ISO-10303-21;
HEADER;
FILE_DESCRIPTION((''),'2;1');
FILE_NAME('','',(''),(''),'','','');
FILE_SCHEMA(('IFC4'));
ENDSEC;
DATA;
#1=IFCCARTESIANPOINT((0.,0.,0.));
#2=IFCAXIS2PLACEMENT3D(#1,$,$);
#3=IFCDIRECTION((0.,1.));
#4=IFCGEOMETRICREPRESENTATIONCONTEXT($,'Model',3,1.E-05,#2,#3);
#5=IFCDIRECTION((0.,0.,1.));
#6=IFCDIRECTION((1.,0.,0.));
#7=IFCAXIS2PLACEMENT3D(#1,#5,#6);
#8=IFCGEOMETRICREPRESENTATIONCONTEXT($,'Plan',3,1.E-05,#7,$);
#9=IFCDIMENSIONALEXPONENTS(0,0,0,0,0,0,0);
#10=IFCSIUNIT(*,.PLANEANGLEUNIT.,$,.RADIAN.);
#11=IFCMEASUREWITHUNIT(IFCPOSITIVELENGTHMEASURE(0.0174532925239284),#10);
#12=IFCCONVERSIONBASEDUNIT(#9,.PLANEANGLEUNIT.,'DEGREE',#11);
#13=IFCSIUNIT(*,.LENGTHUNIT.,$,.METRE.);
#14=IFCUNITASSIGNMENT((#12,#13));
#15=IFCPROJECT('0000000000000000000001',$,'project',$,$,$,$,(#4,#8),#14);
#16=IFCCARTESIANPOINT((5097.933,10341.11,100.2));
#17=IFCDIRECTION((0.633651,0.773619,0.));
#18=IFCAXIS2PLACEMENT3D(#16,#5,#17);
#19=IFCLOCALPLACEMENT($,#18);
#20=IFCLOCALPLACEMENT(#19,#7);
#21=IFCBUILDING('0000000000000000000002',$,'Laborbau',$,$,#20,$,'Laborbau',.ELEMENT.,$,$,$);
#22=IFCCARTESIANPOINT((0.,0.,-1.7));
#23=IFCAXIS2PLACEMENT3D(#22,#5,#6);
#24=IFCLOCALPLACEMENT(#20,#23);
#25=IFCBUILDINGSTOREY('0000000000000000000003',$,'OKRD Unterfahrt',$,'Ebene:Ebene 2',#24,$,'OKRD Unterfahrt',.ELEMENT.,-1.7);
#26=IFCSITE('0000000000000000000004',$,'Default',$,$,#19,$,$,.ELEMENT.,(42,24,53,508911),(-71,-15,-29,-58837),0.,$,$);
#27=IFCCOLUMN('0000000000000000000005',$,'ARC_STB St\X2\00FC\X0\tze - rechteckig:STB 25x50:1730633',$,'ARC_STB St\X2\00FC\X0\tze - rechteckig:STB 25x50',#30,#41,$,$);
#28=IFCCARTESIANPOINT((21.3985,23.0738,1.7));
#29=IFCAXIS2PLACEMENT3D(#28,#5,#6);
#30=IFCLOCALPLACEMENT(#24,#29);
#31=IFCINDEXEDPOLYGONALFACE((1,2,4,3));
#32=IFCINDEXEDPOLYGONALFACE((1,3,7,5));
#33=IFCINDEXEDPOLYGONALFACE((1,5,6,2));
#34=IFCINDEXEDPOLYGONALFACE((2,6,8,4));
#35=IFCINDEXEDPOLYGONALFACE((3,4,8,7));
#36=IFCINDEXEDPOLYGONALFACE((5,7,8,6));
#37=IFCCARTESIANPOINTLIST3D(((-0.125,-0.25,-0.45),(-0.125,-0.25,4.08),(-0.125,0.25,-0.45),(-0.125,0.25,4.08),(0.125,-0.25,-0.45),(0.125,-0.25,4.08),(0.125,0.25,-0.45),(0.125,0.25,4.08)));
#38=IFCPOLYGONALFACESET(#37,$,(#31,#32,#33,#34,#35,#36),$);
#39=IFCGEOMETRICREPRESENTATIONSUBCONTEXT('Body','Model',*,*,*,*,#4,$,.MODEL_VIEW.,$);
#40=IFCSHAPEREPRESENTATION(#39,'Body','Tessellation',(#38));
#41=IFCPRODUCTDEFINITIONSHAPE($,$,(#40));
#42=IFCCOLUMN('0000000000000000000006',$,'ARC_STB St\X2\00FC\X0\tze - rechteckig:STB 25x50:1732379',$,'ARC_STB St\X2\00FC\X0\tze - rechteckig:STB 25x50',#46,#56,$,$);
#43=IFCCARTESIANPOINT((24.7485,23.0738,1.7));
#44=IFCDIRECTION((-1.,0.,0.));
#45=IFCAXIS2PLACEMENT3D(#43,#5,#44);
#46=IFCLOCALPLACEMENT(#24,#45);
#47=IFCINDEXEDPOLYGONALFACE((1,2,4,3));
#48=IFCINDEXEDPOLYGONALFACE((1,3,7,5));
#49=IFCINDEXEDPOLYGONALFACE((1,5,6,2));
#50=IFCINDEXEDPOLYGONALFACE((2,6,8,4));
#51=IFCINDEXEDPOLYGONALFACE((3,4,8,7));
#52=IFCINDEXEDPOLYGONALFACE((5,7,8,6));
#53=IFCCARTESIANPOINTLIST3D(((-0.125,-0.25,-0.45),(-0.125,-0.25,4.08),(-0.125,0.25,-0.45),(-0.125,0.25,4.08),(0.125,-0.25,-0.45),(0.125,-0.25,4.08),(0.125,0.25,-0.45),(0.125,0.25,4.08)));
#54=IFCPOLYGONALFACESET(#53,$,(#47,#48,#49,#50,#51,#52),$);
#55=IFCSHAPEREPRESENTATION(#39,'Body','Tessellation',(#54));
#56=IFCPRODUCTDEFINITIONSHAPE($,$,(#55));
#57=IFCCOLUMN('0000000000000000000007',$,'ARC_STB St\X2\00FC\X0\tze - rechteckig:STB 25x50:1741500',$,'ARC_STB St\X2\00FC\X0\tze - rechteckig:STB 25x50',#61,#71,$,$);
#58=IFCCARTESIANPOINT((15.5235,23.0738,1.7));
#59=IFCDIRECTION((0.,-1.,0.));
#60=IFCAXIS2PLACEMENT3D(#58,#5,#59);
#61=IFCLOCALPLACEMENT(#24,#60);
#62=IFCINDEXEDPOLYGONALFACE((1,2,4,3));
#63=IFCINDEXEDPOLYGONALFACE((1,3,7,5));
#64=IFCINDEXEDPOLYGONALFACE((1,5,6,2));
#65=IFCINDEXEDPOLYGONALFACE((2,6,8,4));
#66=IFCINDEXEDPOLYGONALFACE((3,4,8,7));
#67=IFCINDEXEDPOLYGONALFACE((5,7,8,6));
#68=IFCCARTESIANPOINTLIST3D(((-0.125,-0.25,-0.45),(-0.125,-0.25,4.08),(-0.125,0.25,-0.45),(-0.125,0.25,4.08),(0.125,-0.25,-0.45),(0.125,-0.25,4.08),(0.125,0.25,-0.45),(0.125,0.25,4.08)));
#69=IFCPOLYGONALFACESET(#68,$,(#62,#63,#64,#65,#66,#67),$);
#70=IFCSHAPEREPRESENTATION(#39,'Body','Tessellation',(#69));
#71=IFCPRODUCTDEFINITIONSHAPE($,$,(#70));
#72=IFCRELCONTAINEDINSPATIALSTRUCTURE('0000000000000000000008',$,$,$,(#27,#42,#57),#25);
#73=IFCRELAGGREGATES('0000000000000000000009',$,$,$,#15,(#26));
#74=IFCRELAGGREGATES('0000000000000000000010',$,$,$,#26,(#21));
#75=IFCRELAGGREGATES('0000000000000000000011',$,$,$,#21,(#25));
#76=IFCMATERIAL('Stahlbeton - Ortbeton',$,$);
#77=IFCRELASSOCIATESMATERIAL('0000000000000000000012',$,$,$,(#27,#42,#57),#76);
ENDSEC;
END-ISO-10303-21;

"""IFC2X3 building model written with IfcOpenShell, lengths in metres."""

from ifc_helpers import new_model, entity, si_unit, converted_unit, direction, frame, origin, origin_with_axes, origin_2d_with_axis, place, context, subcontext, project, spatial, rectangle, extrude, source, transform, mapped, material, element, save


model = new_model("IFC2X3")

# Units and contexts
model_context = context("Model", 3, precision=1e-05, world=origin(), true_north=direction((0.0, 1.0)))
plan_context = context("Plan", 3, precision=1e-05, world=origin_with_axes())
body_context = subcontext(model_context, "Body", "Model", "MODEL_VIEW")
ifc_project = project(units=[converted_unit("PLANEANGLEUNIT", "DEGREE", entity("IfcPositiveLengthMeasure", 0.0174532925239284), si_unit("PLANEANGLEUNIT", "RADIAN"), dimensions=[0, 0, 0, 0, 0, 0, 0]), si_unit("LENGTHUNIT", "METRE")], contexts=[model_context, plan_context])

# Site, building, storey
site_placement = place(None, frame((5097.933, 10341.11, 100.2), z_axis=(0.0, 0.0, 1.0), x_axis=(0.633651, 0.773619, 0.0)))
site = spatial("IfcSite", under=ifc_project, at=site_placement, Name="Default", CompositionType="ELEMENT", RefLatitude=(42, 24, 53, 508911), RefLongitude=(-71, -15, -29, -58837), RefElevation=0.0)
building_placement = place(site_placement, origin_with_axes())
building = spatial("IfcBuilding", under=site, at=building_placement, Name="Laborbau", LongName="Laborbau", CompositionType="ELEMENT")
storey_placement = place(building_placement, frame((0.0, 0.0, -1.7), z_axis=(0.0, 0.0, 1.0), x_axis=(1.0, 0.0, 0.0)))
storey = spatial("IfcBuildingStorey", under=building, at=storey_placement, Name="OKRD Unterfahrt", ObjectType="Ebene:Ebene 2", LongName="OKRD Unterfahrt", CompositionType="ELEMENT", Elevation=-1.7)

# Columns
ifc_material_1 = material(Name="Stahlbeton - Ortbeton")
shared_shape = source(origin(), body_context, "Body", "SweptSolid", [
    extrude(rectangle(XDim=0.5, YDim=0.25, at=origin_2d_with_axis()), frame((0.0, 0.0, -0.45), z_axis=(0.0, 0.0, 1.0), x_axis=(0.0, -1.0, 0.0)), (0.0, 0.0, 1.0), 4.53),
])
for number, where, z_axis, x_axis, name in (
    (1, (21.3985, 23.0738, 1.7), (0.0, 0.0, 1.0), (1.0, 0.0, 0.0), "ARC_STB Stütze - rechteckig:STB 25x50:1730633"),
    (2, (24.7485, 23.0738, 1.7), (0.0, 0.0, 1.0), (-1.0, 0.0, 0.0), "ARC_STB Stütze - rechteckig:STB 25x50:1732379"),
    (3, (15.5235, 23.0738, 1.7), (0.0, 0.0, 1.0), (0.0, -1.0, 0.0), "ARC_STB Stütze - rechteckig:STB 25x50:1741500"),
):
    element("IfcColumn", number, at=place(storey_placement, frame(where, z_axis=z_axis, x_axis=x_axis)), inside=storey, material=ifc_material_1, Name=name, ObjectType="ARC_STB Stütze - rechteckig:STB 25x50", context=body_context, shape_type="MappedRepresentation", body=[
        mapped(shared_shape, transform((0.0, 0.0, 0.0), scale=1.0)),
    ])

save(model, "model.ifc")
